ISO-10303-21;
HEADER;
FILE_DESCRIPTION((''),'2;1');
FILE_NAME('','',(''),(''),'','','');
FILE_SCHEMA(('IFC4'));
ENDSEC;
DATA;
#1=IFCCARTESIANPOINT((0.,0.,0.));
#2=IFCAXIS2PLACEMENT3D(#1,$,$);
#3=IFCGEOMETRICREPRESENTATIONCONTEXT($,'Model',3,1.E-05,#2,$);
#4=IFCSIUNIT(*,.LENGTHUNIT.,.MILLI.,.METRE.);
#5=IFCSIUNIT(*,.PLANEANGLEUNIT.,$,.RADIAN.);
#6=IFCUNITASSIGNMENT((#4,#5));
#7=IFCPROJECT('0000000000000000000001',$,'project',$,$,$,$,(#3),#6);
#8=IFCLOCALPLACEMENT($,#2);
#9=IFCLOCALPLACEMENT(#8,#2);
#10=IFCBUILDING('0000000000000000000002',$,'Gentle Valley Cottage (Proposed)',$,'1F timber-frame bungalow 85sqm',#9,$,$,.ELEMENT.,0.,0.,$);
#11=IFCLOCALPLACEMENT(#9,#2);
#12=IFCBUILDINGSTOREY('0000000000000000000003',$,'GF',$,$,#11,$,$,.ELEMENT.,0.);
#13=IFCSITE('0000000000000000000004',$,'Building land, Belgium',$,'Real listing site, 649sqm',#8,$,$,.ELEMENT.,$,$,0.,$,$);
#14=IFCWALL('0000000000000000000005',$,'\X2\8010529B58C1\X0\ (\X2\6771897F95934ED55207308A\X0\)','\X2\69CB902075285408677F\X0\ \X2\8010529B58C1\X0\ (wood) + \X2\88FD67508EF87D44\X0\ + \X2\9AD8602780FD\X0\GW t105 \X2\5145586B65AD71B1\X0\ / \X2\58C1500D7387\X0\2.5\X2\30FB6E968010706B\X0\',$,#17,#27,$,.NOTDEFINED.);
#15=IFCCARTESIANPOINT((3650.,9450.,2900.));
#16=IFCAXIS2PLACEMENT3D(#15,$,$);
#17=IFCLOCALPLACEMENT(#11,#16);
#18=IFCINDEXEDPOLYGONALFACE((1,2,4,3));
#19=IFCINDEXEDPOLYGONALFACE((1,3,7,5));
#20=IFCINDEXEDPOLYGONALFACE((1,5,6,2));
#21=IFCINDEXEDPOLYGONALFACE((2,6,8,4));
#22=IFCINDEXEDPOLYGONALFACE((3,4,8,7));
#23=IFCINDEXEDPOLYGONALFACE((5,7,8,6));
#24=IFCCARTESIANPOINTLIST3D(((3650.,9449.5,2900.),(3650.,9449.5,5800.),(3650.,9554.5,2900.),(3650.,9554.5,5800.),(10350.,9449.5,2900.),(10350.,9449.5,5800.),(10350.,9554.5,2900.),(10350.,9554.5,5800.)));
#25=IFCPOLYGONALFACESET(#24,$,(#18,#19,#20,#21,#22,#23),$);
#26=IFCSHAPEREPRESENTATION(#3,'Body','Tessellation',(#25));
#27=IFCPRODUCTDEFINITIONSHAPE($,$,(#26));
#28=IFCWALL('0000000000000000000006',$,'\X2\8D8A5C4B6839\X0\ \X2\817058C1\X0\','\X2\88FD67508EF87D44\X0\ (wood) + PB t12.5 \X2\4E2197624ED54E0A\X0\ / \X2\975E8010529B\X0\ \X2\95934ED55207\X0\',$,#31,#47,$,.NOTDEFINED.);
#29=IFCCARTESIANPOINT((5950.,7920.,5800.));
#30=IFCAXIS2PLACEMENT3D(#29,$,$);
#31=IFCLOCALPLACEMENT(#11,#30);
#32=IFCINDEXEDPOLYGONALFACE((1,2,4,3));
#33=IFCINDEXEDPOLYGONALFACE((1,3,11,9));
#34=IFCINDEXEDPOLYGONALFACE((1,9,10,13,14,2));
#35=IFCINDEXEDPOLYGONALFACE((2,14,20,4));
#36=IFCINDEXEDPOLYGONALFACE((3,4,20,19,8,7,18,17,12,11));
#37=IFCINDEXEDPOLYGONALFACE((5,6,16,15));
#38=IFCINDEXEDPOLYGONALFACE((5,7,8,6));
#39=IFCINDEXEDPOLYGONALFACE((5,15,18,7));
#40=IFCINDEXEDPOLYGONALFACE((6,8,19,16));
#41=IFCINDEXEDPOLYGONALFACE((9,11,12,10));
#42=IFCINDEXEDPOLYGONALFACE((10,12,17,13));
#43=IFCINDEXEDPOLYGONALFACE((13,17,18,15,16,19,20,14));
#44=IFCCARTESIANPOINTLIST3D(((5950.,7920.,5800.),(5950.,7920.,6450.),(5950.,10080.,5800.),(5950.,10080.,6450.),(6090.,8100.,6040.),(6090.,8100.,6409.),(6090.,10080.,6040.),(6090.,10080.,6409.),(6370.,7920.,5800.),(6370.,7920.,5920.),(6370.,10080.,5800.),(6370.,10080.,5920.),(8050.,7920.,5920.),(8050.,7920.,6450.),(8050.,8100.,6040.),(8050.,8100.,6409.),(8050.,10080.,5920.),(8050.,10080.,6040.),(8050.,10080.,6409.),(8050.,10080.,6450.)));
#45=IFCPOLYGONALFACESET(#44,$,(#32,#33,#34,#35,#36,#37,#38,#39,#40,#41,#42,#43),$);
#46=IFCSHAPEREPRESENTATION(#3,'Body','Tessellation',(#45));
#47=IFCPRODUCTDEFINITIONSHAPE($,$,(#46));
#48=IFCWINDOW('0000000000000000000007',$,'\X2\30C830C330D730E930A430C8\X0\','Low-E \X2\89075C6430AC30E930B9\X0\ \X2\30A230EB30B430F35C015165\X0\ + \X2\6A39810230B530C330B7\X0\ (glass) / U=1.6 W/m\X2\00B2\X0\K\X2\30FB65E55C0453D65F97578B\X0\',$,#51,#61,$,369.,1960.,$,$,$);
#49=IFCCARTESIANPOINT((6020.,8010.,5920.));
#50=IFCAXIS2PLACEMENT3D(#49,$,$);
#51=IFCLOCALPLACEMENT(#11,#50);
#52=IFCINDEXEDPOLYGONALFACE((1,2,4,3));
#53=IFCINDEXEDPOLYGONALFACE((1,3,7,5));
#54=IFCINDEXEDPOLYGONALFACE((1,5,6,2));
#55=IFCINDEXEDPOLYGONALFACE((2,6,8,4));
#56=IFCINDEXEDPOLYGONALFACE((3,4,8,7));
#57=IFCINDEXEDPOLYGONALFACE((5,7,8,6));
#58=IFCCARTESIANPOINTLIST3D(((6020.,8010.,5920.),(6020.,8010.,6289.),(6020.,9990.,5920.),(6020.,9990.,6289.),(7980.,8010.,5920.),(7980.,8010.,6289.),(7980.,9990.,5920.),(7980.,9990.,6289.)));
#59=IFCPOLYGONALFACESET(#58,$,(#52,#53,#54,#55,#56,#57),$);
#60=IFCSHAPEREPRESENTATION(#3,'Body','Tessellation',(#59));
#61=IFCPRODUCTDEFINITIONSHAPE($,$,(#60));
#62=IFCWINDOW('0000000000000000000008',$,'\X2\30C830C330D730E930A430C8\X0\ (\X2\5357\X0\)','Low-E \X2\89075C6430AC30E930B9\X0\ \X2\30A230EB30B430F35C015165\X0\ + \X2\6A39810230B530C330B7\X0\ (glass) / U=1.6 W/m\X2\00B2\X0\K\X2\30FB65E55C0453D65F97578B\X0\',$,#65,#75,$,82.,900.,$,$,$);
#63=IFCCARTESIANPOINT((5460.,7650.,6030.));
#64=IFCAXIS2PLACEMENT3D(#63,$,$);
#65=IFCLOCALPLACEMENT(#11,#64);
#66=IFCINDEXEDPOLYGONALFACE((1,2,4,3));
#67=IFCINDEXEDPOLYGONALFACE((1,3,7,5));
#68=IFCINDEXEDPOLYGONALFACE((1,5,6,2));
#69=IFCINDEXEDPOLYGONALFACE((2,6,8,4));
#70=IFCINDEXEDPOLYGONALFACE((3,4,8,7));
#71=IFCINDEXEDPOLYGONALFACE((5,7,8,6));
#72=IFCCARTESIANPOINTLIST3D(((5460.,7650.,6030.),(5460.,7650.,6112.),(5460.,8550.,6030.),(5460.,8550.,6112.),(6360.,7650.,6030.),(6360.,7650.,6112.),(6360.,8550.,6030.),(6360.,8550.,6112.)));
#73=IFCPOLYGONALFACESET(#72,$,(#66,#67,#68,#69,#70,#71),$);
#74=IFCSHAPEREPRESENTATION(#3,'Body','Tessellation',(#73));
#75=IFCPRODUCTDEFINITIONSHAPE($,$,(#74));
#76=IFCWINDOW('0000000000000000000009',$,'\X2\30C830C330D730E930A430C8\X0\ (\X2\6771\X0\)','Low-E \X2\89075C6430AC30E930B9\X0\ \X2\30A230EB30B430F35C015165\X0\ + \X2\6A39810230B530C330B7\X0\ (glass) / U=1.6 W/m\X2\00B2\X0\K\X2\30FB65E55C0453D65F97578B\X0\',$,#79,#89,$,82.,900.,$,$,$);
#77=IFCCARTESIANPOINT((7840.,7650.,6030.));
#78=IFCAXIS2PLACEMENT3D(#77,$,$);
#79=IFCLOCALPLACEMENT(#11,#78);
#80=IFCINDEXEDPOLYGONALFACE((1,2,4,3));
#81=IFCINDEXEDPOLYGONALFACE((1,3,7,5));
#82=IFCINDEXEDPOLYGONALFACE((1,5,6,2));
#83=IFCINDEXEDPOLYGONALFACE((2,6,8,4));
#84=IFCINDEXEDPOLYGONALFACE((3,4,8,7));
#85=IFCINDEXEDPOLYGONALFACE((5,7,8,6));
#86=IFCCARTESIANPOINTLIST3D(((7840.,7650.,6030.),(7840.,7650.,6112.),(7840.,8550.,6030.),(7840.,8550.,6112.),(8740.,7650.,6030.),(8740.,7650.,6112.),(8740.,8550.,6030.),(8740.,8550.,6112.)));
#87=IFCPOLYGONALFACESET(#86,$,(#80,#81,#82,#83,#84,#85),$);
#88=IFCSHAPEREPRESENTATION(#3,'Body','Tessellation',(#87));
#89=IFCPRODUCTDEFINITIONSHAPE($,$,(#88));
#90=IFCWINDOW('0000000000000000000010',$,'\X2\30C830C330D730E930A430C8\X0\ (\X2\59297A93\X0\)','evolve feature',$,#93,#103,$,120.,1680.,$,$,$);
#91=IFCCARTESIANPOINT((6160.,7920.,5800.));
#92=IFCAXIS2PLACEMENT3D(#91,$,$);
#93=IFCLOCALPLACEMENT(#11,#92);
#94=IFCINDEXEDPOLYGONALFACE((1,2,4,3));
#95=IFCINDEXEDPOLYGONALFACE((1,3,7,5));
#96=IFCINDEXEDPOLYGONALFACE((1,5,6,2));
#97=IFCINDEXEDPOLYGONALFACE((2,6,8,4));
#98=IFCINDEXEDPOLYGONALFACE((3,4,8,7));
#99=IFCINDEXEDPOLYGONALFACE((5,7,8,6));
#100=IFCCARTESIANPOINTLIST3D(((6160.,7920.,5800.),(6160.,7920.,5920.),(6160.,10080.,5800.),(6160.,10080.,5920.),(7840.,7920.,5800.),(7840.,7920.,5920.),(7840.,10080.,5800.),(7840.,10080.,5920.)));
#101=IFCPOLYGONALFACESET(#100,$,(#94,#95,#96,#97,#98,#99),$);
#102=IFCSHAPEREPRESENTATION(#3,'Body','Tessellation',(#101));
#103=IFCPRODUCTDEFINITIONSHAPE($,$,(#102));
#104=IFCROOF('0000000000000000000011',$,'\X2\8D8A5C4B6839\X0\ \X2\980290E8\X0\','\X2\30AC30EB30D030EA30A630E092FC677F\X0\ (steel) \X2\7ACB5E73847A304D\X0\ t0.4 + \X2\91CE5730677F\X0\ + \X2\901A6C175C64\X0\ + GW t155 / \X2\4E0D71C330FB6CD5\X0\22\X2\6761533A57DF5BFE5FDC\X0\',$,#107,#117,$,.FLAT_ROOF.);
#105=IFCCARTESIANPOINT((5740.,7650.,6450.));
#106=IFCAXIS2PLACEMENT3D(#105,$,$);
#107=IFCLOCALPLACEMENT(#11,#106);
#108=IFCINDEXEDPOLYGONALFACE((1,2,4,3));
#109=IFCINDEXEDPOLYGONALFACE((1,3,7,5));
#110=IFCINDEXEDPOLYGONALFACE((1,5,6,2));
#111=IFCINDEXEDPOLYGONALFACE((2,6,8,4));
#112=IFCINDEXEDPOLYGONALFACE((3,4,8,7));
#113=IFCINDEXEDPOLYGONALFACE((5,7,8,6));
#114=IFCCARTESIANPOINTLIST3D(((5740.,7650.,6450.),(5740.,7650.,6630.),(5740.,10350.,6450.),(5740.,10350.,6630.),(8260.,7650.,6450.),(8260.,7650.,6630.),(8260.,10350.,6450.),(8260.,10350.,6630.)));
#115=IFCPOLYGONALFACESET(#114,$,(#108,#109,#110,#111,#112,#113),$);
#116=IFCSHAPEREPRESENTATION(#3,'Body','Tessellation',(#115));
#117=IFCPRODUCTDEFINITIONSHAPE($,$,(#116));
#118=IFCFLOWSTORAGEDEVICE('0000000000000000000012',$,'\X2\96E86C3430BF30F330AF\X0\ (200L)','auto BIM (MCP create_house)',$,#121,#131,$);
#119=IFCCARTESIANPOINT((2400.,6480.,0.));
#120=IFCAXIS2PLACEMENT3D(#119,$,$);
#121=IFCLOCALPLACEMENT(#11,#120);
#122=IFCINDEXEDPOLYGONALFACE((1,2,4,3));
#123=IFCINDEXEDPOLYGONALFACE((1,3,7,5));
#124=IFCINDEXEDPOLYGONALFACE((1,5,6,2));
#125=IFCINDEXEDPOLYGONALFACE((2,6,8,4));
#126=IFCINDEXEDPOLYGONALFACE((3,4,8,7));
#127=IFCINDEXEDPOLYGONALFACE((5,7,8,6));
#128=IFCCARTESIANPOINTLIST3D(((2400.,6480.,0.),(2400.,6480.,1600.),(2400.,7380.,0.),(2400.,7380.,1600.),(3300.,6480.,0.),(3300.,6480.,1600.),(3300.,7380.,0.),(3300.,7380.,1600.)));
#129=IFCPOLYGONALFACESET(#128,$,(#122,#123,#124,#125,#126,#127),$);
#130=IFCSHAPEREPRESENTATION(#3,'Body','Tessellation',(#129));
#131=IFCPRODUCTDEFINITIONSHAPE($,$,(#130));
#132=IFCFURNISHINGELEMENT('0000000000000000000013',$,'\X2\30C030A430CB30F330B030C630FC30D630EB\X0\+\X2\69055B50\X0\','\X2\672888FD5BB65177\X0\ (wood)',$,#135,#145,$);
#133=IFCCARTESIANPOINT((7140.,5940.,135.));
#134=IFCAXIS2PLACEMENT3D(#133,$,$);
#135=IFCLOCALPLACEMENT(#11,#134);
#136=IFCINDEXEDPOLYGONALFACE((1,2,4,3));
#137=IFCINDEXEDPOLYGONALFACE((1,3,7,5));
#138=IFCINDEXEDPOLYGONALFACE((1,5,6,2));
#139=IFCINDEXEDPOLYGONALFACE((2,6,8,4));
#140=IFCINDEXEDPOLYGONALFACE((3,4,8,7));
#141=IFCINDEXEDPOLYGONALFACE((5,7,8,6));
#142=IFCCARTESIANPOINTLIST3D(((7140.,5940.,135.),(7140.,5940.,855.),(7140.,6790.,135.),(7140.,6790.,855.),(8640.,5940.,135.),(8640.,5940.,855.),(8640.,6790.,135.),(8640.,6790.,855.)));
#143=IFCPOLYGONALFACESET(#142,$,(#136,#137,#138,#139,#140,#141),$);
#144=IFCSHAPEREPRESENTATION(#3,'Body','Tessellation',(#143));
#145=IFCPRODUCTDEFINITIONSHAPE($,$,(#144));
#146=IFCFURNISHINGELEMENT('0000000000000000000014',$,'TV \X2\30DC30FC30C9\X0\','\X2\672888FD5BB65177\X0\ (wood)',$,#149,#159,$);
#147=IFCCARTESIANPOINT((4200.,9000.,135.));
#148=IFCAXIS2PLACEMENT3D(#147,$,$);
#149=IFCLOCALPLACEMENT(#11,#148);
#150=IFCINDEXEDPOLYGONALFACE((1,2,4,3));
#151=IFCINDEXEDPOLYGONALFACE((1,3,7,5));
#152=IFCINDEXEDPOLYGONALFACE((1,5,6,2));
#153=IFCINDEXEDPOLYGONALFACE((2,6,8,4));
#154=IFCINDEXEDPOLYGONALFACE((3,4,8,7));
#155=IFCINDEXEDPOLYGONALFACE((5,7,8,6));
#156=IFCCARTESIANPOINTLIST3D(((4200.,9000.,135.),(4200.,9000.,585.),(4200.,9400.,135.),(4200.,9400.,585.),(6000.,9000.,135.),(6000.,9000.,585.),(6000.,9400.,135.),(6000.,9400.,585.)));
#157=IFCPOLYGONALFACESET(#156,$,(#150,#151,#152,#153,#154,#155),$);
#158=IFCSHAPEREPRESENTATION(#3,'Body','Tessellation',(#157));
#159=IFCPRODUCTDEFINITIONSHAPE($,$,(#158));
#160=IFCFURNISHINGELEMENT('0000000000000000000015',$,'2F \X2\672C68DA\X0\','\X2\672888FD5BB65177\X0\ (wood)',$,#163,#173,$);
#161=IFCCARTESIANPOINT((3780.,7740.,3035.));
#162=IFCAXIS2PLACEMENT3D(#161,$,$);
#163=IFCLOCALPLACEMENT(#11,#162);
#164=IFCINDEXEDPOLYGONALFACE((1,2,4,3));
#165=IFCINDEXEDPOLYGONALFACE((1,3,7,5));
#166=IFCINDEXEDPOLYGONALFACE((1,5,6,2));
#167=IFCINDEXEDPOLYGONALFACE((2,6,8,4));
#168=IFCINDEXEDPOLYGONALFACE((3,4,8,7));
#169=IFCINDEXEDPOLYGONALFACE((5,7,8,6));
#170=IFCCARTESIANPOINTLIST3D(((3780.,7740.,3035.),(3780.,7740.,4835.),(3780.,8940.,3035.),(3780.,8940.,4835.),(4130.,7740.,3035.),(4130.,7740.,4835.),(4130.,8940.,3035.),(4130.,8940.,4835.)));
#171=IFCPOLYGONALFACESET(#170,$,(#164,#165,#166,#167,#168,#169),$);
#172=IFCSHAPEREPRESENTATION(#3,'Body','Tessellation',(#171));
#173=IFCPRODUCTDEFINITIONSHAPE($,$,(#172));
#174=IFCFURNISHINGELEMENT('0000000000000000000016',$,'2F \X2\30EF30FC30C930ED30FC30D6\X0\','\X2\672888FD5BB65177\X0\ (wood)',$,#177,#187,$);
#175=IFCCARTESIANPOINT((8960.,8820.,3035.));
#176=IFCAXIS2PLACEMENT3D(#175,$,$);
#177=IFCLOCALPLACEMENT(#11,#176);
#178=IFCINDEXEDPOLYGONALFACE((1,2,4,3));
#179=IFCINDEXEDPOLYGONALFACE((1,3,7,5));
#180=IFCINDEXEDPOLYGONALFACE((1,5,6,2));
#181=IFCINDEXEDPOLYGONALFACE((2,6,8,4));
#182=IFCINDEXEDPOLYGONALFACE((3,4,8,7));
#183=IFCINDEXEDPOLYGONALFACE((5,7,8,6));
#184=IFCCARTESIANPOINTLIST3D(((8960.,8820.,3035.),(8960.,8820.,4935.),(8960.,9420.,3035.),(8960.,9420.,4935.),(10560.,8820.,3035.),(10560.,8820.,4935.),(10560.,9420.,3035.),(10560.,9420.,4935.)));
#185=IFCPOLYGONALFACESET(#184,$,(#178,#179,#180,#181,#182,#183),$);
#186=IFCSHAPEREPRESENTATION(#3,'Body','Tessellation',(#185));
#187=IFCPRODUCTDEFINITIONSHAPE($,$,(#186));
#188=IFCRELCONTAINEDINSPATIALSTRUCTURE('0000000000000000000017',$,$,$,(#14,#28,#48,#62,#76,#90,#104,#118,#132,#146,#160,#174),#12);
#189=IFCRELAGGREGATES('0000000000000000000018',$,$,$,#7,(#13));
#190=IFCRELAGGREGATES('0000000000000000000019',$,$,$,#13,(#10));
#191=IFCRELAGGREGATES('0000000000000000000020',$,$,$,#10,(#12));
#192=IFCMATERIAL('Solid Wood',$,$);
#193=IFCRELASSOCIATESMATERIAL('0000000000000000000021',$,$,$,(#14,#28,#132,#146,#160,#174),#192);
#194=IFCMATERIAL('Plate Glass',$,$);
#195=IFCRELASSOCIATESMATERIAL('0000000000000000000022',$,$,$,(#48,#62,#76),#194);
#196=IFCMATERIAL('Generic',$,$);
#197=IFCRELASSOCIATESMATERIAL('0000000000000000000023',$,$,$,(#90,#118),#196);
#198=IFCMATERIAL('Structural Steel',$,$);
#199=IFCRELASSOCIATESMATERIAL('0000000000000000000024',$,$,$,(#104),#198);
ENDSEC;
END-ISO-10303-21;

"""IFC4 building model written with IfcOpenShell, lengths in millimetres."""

from ifc_helpers import new_model, si_unit, frame, frame_2d, origin, place, context, project, spatial, rectangle, extrude, material, element, fill, save


model = new_model("IFC4")

# Units and contexts
model_context = context("Model", 3, precision=1e-05, world=origin())
ifc_project = project(units=[si_unit("LENGTHUNIT", "METRE", prefix="MILLI"), si_unit("PLANEANGLEUNIT", "RADIAN")], contexts=[model_context])

# Site, building, storey
site_placement = place(None, origin())
site = spatial("IfcSite", under=ifc_project, at=site_placement, Name="Building land, Belgium", ObjectType="Real listing site, 649sqm", CompositionType="ELEMENT", RefElevation=0.0)
building_placement = place(site_placement, origin())
building = spatial("IfcBuilding", under=site, at=building_placement, Name="Gentle Valley Cottage (Proposed)", ObjectType="1F timber-frame bungalow 85sqm", CompositionType="ELEMENT", ElevationOfRefHeight=0.0, ElevationOfTerrain=0.0)
storey_placement = place(building_placement, origin())
storey = spatial("IfcBuildingStorey", under=building, at=storey_placement, Name="GF", CompositionType="ELEMENT", Elevation=0.0)

# Wall
ifc_material_1 = material(Name="Solid Wood")
wall_1_placement = place(storey_placement, frame((3650.0, 9450.0, 2900.0)))
element("IfcWall", 1, at=wall_1_placement, inside=storey, material=ifc_material_1, Name="耐力壁 (東西間仕切り)", Description="構造用合板 耐力壁 (wood) + 製材軸組 + 高性能GW t105 充填断熱 / 壁倍率2.5・準耐火", PredefinedType="NOTDEFINED", context=model_context, shape_type="SweptSolid", body=[
    extrude(rectangle(XDim=6700.0, YDim=105.0, at=frame_2d((3350.0, 52.0))), frame((3650.0, 9450.0, 2900.0)), (0.0, 0.0, 1.0), 2900.0),
])

# Wall, openings, windows
wall_2_placement = place(storey_placement, frame((5950.0, 7920.0, 5800.0)))
wall_2 = element("IfcWall", 2, at=wall_2_placement, inside=storey, material=ifc_material_1, Name="越屋根 腰壁", Description="製材軸組 (wood) + PB t12.5 両面仕上 / 非耐力 間仕切", PredefinedType="NOTDEFINED", context=model_context, shape_type="SweptSolid", body=[
    extrude(rectangle(XDim=2100.0, YDim=2160.0, at=frame_2d((1050.0, 1080.0))), frame((5950.0, 7920.0, 5800.0)), (0.0, 0.0, 1.0), 650.0),
])
opening_1_placement = place(storey_placement, frame((6020.0, 8010.0, 5920.0)))
opening_1 = element("IfcOpeningElement", 3, at=opening_1_placement, cuts=wall_2, PredefinedType="NOTDEFINED", context=model_context, shape_type="SweptSolid", body=[
    extrude(rectangle(XDim=1960.0, YDim=1980.0, at=frame_2d((980.0, 990.0))), frame((6020.0, 8010.0, 5920.0)), (0.0, 0.0, 1.0), 369.0),
])
opening_2_placement = place(storey_placement, frame((5460.0, 7650.0, 6030.0)))
opening_2 = element("IfcOpeningElement", 4, at=opening_2_placement, cuts=wall_2, PredefinedType="NOTDEFINED", context=model_context, shape_type="SweptSolid", body=[
    extrude(rectangle(XDim=900.0, YDim=900.0, at=frame_2d((450.0, 450.0))), frame((5460.0, 7650.0, 6030.0)), (0.0, 0.0, 1.0), 82.0),
])
opening_3_placement = place(storey_placement, frame((7840.0, 7650.0, 6030.0)))
opening_3 = element("IfcOpeningElement", 5, at=opening_3_placement, cuts=wall_2, PredefinedType="NOTDEFINED", context=model_context, shape_type="SweptSolid", body=[
    extrude(rectangle(XDim=900.0, YDim=900.0, at=frame_2d((450.0, 450.0))), frame((7840.0, 7650.0, 6030.0)), (0.0, 0.0, 1.0), 82.0),
])
opening_4_placement = place(storey_placement, frame((6160.0, 7920.0, 5800.0)))
opening_4 = element("IfcOpeningElement", 6, at=opening_4_placement, cuts=wall_2, PredefinedType="NOTDEFINED", context=model_context, shape_type="SweptSolid", body=[
    extrude(rectangle(XDim=1680.0, YDim=2160.0, at=frame_2d((840.0, 1080.0))), frame((6160.0, 7920.0, 5800.0)), (0.0, 0.0, 1.0), 120.0),
])
ifc_material_2 = material(Name="Plate Glass")
window_1_placement = place(storey_placement, frame((6020.0, 8010.0, 5920.0)))
window_1 = element("IfcWindow", 7, at=window_1_placement, inside=storey, material=ifc_material_2, Name="トップライト", Description="Low-E 複層ガラス アルゴン封入 + 樹脂サッシ (glass) / U=1.6 W/m²K・日射取得型", OverallHeight=369.0, OverallWidth=1960.0, context=model_context, shape_type="SweptSolid", body=[
    extrude(rectangle(XDim=1960.0, YDim=1980.0, at=frame_2d((980.0, 990.0))), frame((6020.0, 8010.0, 5920.0)), (0.0, 0.0, 1.0), 369.0),
])
fill(opening_1, window_1)
window_2_placement = place(storey_placement, frame((5460.0, 7650.0, 6030.0)))
window_2 = element("IfcWindow", 8, at=window_2_placement, inside=storey, material=ifc_material_2, Name="トップライト (南)", Description="Low-E 複層ガラス アルゴン封入 + 樹脂サッシ (glass) / U=1.6 W/m²K・日射取得型", OverallHeight=82.0, OverallWidth=900.0, context=model_context, shape_type="SweptSolid", body=[
    extrude(rectangle(XDim=900.0, YDim=900.0, at=frame_2d((450.0, 450.0))), frame((5460.0, 7650.0, 6030.0)), (0.0, 0.0, 1.0), 82.0),
])
fill(opening_2, window_2)
window_3_placement = place(storey_placement, frame((7840.0, 7650.0, 6030.0)))
window_3 = element("IfcWindow", 9, at=window_3_placement, inside=storey, material=ifc_material_2, Name="トップライト (東)", Description="Low-E 複層ガラス アルゴン封入 + 樹脂サッシ (glass) / U=1.6 W/m²K・日射取得型", OverallHeight=82.0, OverallWidth=900.0, context=model_context, shape_type="SweptSolid", body=[
    extrude(rectangle(XDim=900.0, YDim=900.0, at=frame_2d((450.0, 450.0))), frame((7840.0, 7650.0, 6030.0)), (0.0, 0.0, 1.0), 82.0),
])
fill(opening_3, window_3)
ifc_material_3 = material(Name="Generic")
window_4_placement = place(storey_placement, frame((6160.0, 7920.0, 5800.0)))
window_4 = element("IfcWindow", 10, at=window_4_placement, inside=storey, material=ifc_material_3, Name="トップライト (天窓)", Description="evolve feature", OverallHeight=120.0, OverallWidth=1680.0, context=model_context, shape_type="SweptSolid", body=[
    extrude(rectangle(XDim=1680.0, YDim=2160.0, at=frame_2d((840.0, 1080.0))), frame((6160.0, 7920.0, 5800.0)), (0.0, 0.0, 1.0), 120.0),
])
fill(opening_4, window_4)

# Roof
ifc_material_4 = material(Name="Structural Steel")
roof_placement = place(storey_placement, frame((5740.0, 7650.0, 6450.0)))
element("IfcRoof", 11, at=roof_placement, inside=storey, material=ifc_material_4, Name="越屋根 頂部", Description="ガルバリウム鋼板 (steel) 立平葺き t0.4 + 野地板 + 通気層 + GW t155 / 不燃・法22条区域対応", PredefinedType="FLAT_ROOF", context=model_context, shape_type="SweptSolid", body=[
    extrude(rectangle(XDim=2520.0, YDim=2700.0, at=frame_2d((1260.0, 1350.0))), frame((5740.0, 7650.0, 6450.0)), (0.0, 0.0, 1.0), 180.0),
])

# Flow storage device
flow_storage_device_placement = place(storey_placement, frame((2400.0, 6480.0, 0.0)))
element("IfcFlowStorageDevice", 12, at=flow_storage_device_placement, inside=storey, material=ifc_material_3, Name="雨水タンク (200L)", Description="auto BIM (MCP create_house)", context=model_context, shape_type="SweptSolid", body=[
    extrude(rectangle(XDim=900.0, YDim=900.0, at=frame_2d((450.0, 450.0))), frame((2400.0, 6480.0, 0.0)), (0.0, 0.0, 1.0), 1600.0),
])

# Furnishing elements
furnishing_1_placement = place(storey_placement, frame((7140.0, 5940.0, 135.0)))
element("IfcFurnishingElement", 13, at=furnishing_1_placement, inside=storey, material=ifc_material_1, Name="ダイニングテーブル+椅子", Description="木製家具 (wood)", context=model_context, shape_type="SweptSolid", body=[
    extrude(rectangle(XDim=1500.0, YDim=850.0, at=frame_2d((750.0, 425.0))), frame((7140.0, 5940.0, 135.0)), (0.0, 0.0, 1.0), 720.0),
])
furnishing_2_placement = place(storey_placement, frame((4200.0, 9000.0, 135.0)))
element("IfcFurnishingElement", 14, at=furnishing_2_placement, inside=storey, material=ifc_material_1, Name="TV ボード", Description="木製家具 (wood)", context=model_context, shape_type="SweptSolid", body=[
    extrude(rectangle(XDim=1800.0, YDim=400.0, at=frame_2d((900.0, 200.0))), frame((4200.0, 9000.0, 135.0)), (0.0, 0.0, 1.0), 450.0),
])
furnishing_3_placement = place(storey_placement, frame((3780.0, 7740.0, 3035.0)))
element("IfcFurnishingElement", 15, at=furnishing_3_placement, inside=storey, material=ifc_material_1, Name="2F 本棚", Description="木製家具 (wood)", context=model_context, shape_type="SweptSolid", body=[
    extrude(rectangle(XDim=350.0, YDim=1200.0, at=frame_2d((175.0, 600.0))), frame((3780.0, 7740.0, 3035.0)), (0.0, 0.0, 1.0), 1800.0),
])
furnishing_4_placement = place(storey_placement, frame((8960.0, 8820.0, 3035.0)))
element("IfcFurnishingElement", 16, at=furnishing_4_placement, inside=storey, material=ifc_material_1, Name="2F ワードローブ", Description="木製家具 (wood)", context=model_context, shape_type="SweptSolid", body=[
    extrude(rectangle(XDim=1600.0, YDim=600.0, at=frame_2d((800.0, 300.0))), frame((8960.0, 8820.0, 3035.0)), (0.0, 0.0, 1.0), 1900.0),
])

save(model, "model.ifc")
